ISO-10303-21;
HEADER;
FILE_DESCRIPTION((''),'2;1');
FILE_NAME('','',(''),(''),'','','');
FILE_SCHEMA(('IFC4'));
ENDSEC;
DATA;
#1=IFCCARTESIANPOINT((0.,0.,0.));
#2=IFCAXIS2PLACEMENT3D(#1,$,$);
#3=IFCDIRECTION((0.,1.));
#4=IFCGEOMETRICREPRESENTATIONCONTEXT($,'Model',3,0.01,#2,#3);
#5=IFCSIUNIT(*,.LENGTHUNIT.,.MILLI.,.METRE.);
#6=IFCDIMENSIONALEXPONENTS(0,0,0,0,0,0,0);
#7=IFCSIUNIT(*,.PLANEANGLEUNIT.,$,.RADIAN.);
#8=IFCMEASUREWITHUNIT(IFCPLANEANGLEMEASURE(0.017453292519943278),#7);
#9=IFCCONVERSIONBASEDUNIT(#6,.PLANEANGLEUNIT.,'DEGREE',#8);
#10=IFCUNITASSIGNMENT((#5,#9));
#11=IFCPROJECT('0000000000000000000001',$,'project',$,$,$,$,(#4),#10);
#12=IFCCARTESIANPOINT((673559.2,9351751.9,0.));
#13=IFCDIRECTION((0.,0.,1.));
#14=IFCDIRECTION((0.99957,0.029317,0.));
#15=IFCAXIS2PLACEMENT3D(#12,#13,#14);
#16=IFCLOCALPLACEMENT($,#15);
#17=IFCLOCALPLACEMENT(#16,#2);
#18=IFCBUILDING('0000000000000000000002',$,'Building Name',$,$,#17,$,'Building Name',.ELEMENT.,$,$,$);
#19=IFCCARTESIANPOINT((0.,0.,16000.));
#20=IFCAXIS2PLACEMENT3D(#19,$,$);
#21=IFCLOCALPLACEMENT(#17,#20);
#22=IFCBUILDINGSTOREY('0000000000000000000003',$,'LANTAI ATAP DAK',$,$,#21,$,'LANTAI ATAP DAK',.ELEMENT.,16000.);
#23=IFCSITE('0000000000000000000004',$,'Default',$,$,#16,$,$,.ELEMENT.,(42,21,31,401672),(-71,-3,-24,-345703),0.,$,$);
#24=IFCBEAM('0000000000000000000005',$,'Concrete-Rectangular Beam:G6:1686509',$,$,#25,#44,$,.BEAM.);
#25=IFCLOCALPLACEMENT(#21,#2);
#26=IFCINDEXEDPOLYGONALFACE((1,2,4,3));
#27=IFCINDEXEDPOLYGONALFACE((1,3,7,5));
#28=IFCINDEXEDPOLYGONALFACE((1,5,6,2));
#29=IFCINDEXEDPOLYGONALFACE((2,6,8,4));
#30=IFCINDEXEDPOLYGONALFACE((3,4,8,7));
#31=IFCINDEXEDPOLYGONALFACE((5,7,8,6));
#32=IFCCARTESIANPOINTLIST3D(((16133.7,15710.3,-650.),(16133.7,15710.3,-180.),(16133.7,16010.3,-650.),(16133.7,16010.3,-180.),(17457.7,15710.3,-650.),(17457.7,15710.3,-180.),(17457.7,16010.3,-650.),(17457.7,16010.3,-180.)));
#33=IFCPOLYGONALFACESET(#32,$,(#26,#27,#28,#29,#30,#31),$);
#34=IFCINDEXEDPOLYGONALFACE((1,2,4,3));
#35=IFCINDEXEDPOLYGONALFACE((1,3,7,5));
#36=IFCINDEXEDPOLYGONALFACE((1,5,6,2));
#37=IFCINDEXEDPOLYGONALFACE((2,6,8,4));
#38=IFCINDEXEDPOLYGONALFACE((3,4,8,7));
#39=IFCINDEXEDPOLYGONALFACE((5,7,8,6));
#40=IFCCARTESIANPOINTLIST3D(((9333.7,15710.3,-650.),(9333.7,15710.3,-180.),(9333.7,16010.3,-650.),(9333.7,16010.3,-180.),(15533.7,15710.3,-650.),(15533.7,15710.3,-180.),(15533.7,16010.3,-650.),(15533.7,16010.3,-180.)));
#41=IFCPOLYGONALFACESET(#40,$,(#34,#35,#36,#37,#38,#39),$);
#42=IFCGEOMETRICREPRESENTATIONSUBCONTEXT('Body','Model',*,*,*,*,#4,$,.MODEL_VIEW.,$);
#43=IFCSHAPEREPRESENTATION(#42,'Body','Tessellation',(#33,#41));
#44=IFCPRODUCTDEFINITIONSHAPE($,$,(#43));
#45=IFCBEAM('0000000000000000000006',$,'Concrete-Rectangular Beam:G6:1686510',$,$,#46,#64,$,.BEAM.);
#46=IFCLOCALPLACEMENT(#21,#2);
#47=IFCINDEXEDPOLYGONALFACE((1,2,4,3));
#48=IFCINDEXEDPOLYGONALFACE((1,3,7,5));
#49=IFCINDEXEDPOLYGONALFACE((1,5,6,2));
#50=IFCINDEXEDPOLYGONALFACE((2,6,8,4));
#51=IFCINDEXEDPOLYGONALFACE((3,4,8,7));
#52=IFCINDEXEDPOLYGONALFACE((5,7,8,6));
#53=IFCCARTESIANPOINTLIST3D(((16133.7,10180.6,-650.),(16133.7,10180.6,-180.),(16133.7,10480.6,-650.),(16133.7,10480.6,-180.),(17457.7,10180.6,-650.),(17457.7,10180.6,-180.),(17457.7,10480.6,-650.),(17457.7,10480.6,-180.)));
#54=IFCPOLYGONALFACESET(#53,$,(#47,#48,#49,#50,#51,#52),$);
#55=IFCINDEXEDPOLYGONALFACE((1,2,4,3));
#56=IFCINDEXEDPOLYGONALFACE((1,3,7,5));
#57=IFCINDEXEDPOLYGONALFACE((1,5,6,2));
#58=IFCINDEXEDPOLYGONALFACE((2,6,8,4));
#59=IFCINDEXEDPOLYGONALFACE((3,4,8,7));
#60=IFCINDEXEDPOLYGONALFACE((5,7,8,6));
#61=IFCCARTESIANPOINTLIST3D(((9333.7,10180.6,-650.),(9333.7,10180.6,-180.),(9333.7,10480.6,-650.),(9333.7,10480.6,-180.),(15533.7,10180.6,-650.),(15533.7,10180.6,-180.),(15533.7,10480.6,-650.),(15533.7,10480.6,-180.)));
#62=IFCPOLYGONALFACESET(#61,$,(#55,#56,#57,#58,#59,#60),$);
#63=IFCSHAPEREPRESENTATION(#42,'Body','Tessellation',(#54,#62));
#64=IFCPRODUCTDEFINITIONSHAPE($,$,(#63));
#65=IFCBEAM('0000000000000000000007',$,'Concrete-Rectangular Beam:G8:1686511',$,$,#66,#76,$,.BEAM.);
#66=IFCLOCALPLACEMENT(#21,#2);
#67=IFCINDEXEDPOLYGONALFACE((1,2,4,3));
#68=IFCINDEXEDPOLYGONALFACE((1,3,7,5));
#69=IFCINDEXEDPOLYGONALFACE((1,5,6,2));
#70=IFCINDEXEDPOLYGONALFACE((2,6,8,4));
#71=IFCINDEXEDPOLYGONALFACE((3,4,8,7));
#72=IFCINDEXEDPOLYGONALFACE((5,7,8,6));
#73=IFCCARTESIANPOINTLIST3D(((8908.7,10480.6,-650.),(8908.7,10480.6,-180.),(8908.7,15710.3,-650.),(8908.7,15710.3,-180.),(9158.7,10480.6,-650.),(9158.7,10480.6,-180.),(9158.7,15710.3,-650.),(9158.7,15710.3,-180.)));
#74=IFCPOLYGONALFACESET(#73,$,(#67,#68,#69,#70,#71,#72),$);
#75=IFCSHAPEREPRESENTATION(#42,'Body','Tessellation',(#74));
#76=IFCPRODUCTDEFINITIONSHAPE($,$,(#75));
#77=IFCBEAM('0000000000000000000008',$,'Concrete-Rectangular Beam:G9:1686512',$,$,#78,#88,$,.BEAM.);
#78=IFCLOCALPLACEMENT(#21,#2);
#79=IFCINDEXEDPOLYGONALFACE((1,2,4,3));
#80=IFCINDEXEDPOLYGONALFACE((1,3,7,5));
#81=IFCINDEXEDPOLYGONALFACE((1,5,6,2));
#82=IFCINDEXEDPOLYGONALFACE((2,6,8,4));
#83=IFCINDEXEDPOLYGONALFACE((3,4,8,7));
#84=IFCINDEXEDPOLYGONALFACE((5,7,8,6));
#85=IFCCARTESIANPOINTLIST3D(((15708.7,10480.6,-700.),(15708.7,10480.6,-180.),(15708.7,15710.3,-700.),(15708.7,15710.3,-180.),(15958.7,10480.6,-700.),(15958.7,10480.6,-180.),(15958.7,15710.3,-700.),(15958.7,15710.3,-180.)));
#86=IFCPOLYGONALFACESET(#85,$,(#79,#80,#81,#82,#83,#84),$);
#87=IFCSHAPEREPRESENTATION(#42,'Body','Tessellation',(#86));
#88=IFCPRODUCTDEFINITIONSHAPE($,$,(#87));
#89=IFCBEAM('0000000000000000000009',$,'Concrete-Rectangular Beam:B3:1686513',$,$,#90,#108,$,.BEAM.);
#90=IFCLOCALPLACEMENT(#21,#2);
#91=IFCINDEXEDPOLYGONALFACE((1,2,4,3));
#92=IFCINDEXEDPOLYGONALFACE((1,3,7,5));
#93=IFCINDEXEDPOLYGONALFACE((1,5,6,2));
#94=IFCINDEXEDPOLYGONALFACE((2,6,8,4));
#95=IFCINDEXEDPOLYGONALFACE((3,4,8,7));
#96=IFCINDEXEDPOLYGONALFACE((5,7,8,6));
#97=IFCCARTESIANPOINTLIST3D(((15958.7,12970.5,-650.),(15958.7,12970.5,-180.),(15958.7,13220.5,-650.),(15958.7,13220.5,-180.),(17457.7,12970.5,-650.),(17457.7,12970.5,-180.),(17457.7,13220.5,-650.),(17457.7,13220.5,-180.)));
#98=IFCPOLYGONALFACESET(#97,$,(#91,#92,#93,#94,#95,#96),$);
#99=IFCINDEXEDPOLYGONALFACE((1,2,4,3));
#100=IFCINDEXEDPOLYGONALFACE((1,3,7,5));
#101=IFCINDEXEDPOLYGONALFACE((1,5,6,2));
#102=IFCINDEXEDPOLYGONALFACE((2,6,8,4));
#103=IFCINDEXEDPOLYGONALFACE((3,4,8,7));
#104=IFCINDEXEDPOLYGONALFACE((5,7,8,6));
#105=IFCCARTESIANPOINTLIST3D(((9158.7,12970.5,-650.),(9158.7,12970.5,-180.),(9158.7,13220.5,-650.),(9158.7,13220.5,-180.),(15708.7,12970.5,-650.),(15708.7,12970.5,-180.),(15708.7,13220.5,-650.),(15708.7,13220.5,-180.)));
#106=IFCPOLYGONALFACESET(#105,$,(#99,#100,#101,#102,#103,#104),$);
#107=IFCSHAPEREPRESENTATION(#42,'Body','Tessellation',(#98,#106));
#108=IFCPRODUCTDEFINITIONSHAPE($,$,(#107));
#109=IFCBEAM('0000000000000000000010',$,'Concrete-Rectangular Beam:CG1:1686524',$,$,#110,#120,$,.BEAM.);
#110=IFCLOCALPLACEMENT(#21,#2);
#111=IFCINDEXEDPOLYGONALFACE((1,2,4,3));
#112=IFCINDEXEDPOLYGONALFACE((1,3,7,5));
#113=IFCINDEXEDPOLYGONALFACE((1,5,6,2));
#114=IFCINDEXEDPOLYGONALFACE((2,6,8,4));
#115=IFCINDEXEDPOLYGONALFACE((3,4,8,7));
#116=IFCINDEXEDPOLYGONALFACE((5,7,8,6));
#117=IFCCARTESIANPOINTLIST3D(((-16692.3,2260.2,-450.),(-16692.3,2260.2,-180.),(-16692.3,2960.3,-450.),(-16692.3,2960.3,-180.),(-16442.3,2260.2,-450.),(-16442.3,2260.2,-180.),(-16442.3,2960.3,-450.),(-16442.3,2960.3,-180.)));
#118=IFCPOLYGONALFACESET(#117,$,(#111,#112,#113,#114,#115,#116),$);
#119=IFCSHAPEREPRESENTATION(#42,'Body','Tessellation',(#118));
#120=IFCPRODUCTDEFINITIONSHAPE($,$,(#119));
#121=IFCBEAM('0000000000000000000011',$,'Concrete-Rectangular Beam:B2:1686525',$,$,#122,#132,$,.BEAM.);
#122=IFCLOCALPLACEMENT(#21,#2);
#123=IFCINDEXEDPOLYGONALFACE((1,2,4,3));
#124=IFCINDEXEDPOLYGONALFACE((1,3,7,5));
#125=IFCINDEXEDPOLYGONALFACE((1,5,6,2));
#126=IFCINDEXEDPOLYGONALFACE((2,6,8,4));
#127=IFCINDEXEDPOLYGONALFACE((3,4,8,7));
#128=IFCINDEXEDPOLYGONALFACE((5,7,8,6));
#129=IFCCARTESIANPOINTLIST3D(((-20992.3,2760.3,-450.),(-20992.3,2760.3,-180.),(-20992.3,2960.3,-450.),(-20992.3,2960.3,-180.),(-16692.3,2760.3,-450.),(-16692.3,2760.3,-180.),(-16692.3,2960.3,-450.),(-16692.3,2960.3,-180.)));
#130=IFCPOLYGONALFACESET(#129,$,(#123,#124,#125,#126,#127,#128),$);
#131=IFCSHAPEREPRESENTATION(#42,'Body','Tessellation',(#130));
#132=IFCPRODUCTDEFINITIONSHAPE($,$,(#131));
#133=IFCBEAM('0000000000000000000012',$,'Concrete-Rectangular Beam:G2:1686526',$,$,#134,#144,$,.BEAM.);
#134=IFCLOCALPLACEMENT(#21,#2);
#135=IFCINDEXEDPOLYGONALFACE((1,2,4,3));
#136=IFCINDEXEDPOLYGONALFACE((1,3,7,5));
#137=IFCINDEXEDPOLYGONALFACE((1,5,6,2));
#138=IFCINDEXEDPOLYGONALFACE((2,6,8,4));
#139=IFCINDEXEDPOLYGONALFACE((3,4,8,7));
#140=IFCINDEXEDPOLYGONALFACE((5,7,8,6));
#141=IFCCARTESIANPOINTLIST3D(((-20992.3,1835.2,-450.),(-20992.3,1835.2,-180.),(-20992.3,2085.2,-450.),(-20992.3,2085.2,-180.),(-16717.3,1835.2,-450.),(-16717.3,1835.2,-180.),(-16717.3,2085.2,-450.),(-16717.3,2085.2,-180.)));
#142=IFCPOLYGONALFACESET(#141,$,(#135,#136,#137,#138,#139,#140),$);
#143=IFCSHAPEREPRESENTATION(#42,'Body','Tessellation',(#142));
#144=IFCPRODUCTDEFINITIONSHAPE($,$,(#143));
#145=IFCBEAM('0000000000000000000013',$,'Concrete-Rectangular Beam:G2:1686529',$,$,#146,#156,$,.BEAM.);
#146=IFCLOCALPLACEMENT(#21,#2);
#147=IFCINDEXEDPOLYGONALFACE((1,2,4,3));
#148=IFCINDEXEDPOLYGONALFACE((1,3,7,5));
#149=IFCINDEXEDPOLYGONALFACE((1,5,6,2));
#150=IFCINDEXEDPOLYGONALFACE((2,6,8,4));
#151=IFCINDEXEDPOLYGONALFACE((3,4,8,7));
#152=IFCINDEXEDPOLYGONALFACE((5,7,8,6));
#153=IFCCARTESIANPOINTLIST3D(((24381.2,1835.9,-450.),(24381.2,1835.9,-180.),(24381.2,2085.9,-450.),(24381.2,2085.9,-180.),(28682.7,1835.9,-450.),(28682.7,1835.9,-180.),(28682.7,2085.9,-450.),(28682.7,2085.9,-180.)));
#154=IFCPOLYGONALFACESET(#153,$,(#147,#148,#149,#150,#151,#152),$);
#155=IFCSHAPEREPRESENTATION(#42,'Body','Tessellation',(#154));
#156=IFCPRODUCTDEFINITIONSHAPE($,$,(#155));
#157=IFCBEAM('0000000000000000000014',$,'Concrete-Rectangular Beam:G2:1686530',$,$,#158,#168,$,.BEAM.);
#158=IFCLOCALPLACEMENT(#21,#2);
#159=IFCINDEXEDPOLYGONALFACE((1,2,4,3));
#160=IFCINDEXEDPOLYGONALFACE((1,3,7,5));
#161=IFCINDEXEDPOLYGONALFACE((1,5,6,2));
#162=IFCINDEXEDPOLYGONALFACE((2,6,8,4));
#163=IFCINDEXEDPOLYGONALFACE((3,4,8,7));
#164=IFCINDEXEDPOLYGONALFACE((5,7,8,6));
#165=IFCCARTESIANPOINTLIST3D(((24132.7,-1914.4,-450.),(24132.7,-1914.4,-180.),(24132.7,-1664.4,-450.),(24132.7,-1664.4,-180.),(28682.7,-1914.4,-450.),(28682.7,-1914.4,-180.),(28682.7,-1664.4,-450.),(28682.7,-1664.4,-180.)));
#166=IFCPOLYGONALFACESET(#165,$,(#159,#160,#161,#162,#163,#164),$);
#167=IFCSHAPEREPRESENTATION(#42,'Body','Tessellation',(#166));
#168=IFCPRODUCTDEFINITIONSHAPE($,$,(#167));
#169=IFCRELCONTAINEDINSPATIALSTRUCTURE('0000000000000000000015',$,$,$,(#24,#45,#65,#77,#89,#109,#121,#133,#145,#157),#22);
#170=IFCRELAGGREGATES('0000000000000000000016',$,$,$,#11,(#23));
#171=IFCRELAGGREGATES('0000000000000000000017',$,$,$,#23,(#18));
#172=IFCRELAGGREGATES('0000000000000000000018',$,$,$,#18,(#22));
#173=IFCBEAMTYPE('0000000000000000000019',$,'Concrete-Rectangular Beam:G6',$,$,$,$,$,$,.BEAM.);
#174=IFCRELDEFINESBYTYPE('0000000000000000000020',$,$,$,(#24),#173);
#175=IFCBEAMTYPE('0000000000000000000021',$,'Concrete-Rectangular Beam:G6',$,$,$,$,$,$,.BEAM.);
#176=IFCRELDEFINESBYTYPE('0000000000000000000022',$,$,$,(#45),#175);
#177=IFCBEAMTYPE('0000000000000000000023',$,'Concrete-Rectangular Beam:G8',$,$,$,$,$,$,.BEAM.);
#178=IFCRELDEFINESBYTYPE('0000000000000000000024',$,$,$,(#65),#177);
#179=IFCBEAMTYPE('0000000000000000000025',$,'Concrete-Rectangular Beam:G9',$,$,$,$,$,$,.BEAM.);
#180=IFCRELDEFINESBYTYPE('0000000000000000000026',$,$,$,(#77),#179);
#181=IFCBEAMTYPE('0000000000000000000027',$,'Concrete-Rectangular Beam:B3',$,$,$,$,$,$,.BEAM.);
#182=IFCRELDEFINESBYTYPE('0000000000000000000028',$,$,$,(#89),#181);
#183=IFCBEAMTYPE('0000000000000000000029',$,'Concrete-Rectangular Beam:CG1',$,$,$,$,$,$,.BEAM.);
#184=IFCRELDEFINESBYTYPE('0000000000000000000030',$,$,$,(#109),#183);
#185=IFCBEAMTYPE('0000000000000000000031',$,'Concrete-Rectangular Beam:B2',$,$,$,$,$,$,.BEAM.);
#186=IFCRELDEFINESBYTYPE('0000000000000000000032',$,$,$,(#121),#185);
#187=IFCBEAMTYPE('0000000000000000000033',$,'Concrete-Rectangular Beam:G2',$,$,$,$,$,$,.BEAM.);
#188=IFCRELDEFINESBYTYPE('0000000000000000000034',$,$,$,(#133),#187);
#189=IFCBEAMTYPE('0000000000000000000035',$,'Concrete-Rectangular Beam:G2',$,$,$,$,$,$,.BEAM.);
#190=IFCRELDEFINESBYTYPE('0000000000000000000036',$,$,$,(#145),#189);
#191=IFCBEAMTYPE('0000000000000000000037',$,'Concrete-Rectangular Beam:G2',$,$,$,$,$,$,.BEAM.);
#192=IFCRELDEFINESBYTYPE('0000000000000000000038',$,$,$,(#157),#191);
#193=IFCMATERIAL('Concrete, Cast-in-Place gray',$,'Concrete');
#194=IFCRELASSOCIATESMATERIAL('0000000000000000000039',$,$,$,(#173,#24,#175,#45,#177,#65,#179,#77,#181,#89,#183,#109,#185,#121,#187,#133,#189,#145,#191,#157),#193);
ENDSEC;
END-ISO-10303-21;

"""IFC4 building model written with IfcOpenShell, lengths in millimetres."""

from ifc_helpers import new_model, entity, si_unit, converted_unit, direction, frame, origin, place, context, subcontext, project, spatial, indexed_curve, outline, extrude, source, transform, mapped, material, type_object, type_shapes, element, save


model = new_model("IFC4")

# Units and contexts
model_context = context("Model", 3, precision=0.01, world=origin(), true_north=direction((0.0, 1.0)))
body_context = subcontext(model_context, "Body", "Model", "MODEL_VIEW")
ifc_project = project(units=[si_unit("LENGTHUNIT", "METRE", prefix="MILLI"), converted_unit("PLANEANGLEUNIT", "DEGREE", entity("IfcPlaneAngleMeasure", 0.017453292519943278), si_unit("PLANEANGLEUNIT", "RADIAN"), dimensions=[0, 0, 0, 0, 0, 0, 0])], contexts=[model_context])

# Site, building, storey
site_placement = place(None, frame((673559.2, 9351751.9, 0.0), z_axis=(0.0, 0.0, 1.0), x_axis=(0.99957, 0.029317, 0.0)))
site = spatial("IfcSite", under=ifc_project, at=site_placement, Name="Default", CompositionType="ELEMENT", RefLatitude=(42, 21, 31, 401672), RefLongitude=(-71, -3, -24, -345703), RefElevation=0.0)
building_placement = place(site_placement, origin())
building = spatial("IfcBuilding", under=site, at=building_placement, Name="Building Name", LongName="Building Name", CompositionType="ELEMENT")
storey_placement = place(building_placement, frame((0.0, 0.0, 16000.0)))
storey = spatial("IfcBuildingStorey", under=building, at=storey_placement, Name="LANTAI ATAP DAK", LongName="LANTAI ATAP DAK", CompositionType="ELEMENT", Elevation=16000.0)

# Beams
ifc_material = material(Name="Concrete, Cast-in-Place gray", Category="Concrete")
beam_type_1 = type_object("IfcBeamType", Name="Concrete-Rectangular Beam:G6", PredefinedType="BEAM", material=ifc_material)
shared_shape_1 = source(origin(), body_context, "Body", "SweptSolid", [
    extrude(outline(indexed_curve([(-235.0, -150.0), (235.0, -150.0), (235.0, 150.0), (-235.0, 150.0), (-235.0, -150.0)], self_intersect=False)), frame((16133.7, 15860.3, 15585.0), z_axis=(1.0, 0.0, 0.0), x_axis=(0.0, 0.0, -1.0)), (0.0, 0.0, 1.0), 1324.0),
    extrude(outline(indexed_curve([(-235.0, -150.0), (235.0, -150.0), (235.0, 150.0), (-235.0, 150.0), (-235.0, -150.0)], self_intersect=False)), frame((9333.7, 15860.3, 15585.0), z_axis=(1.0, 0.0, 0.0), x_axis=(0.0, 0.0, -1.0)), (0.0, 0.0, 1.0), 6200.0),
])
type_shapes(beam_type_1, [shared_shape_1])
beam_1_placement = place(storey_placement, frame((0.0, 0.0, -16000.0)))
element("IfcBeam", 1, at=beam_1_placement, inside=storey, type_object=beam_type_1, material=ifc_material, Name="Concrete-Rectangular Beam:G6:1686509", PredefinedType="BEAM", context=body_context, shape_type="MappedRepresentation", body=[
    mapped(shared_shape_1, transform((0.0, 0.0, 0.0), scale=1.0)),
])
beam_type_2 = type_object("IfcBeamType", Name="Concrete-Rectangular Beam:G6", PredefinedType="BEAM", material=ifc_material)
shared_shape_2 = source(origin(), body_context, "Body", "SweptSolid", [
    extrude(outline(indexed_curve([(-235.0, -150.0), (235.0, -150.0), (235.0, 150.0), (-235.0, 150.0), (-235.0, -150.0)], self_intersect=False)), frame((16133.7, 10330.6, 15585.0), z_axis=(1.0, 0.0, 0.0), x_axis=(0.0, 0.0, -1.0)), (0.0, 0.0, 1.0), 1324.0),
    extrude(outline(indexed_curve([(-235.0, -150.0), (235.0, -150.0), (235.0, 150.0), (-235.0, 150.0), (-235.0, -150.0)], self_intersect=False)), frame((9333.7, 10330.6, 15585.0), z_axis=(1.0, 0.0, 0.0), x_axis=(0.0, 0.0, -1.0)), (0.0, 0.0, 1.0), 6200.0),
])
type_shapes(beam_type_2, [shared_shape_2])
beam_2_placement = place(storey_placement, frame((0.0, 0.0, -16000.0)))
element("IfcBeam", 2, at=beam_2_placement, inside=storey, type_object=beam_type_2, material=ifc_material, Name="Concrete-Rectangular Beam:G6:1686510", PredefinedType="BEAM", context=body_context, shape_type="MappedRepresentation", body=[
    mapped(shared_shape_2, transform((0.0, 0.0, 0.0), scale=1.0)),
])
beam_type_3 = type_object("IfcBeamType", Name="Concrete-Rectangular Beam:G8", PredefinedType="BEAM", material=ifc_material)
shared_shape_3 = source(origin(), body_context, "Body", "SweptSolid", [
    extrude(outline(indexed_curve([(-125.0, -235.0), (125.0, -235.0), (125.0, 235.0), (-125.0, 235.0), (-125.0, -235.0)], self_intersect=False)), frame((9033.7, 15710.3, 15585.0), z_axis=(0.0, -1.0, 0.0), x_axis=(-1.0, 0.0, 0.0)), (0.0, 0.0, 1.0), 5229.7),
])
type_shapes(beam_type_3, [shared_shape_3])
beam_3_placement = place(storey_placement, frame((0.0, 0.0, -16000.0)))
element("IfcBeam", 3, at=beam_3_placement, inside=storey, type_object=beam_type_3, material=ifc_material, Name="Concrete-Rectangular Beam:G8:1686511", PredefinedType="BEAM", context=body_context, shape_type="MappedRepresentation", body=[
    mapped(shared_shape_3, transform((0.0, 0.0, 0.0), scale=1.0)),
])
beam_type_4 = type_object("IfcBeamType", Name="Concrete-Rectangular Beam:G9", PredefinedType="BEAM", material=ifc_material)
shared_shape_4 = source(origin(), body_context, "Body", "SweptSolid", [
    extrude(outline(indexed_curve([(-125.0, -260.0), (125.0, -260.0), (125.0, 260.0), (-125.0, 260.0), (-125.0, -260.0)], self_intersect=False)), frame((15833.7, 15710.3, 15560.0), z_axis=(0.0, -1.0, 0.0), x_axis=(-1.0, 0.0, 0.0)), (0.0, 0.0, 1.0), 5229.7),
])
type_shapes(beam_type_4, [shared_shape_4])
beam_4_placement = place(storey_placement, frame((0.0, 0.0, -16000.0)))
element("IfcBeam", 4, at=beam_4_placement, inside=storey, type_object=beam_type_4, material=ifc_material, Name="Concrete-Rectangular Beam:G9:1686512", PredefinedType="BEAM", context=body_context, shape_type="MappedRepresentation", body=[
    mapped(shared_shape_4, transform((0.0, 0.0, 0.0), scale=1.0)),
])
beam_type_5 = type_object("IfcBeamType", Name="Concrete-Rectangular Beam:B3", PredefinedType="BEAM", material=ifc_material)
shared_shape_5 = source(origin(), body_context, "Body", "SweptSolid", [
    extrude(outline(indexed_curve([(-235.0, -125.0), (235.0, -125.0), (235.0, 125.0), (-235.0, 125.0), (-235.0, -125.0)], self_intersect=False)), frame((15958.7, 13095.5, 15585.0), z_axis=(1.0, 0.0, 0.0), x_axis=(0.0, 0.0, -1.0)), (0.0, 0.0, 1.0), 1499.0),
    extrude(outline(indexed_curve([(-235.0, -125.0), (235.0, -125.0), (235.0, 125.0), (-235.0, 125.0), (-235.0, -125.0)], self_intersect=False)), frame((9158.7, 13095.5, 15585.0), z_axis=(1.0, 0.0, 0.0), x_axis=(0.0, 0.0, -1.0)), (0.0, 0.0, 1.0), 6550.0),
])
type_shapes(beam_type_5, [shared_shape_5])
beam_5_placement = place(storey_placement, frame((0.0, 0.0, -16000.0)))
element("IfcBeam", 5, at=beam_5_placement, inside=storey, type_object=beam_type_5, material=ifc_material, Name="Concrete-Rectangular Beam:B3:1686513", PredefinedType="BEAM", context=body_context, shape_type="MappedRepresentation", body=[
    mapped(shared_shape_5, transform((0.0, 0.0, 0.0), scale=1.0)),
])
beam_type_6 = type_object("IfcBeamType", Name="Concrete-Rectangular Beam:CG1", PredefinedType="BEAM", material=ifc_material)
shared_shape_6 = source(origin(), body_context, "Body", "SweptSolid", [
    extrude(outline(indexed_curve([(-125.0, -135.0), (125.0, -135.0), (125.0, 135.0), (-125.0, 135.0), (-125.0, -135.0)], self_intersect=False)), frame((-16567.3, 2260.2, 15685.0), z_axis=(0.0, 1.0, 0.0), x_axis=(-1.0, 0.0, 0.0)), (0.0, 0.0, 1.0), 700.1),
])
type_shapes(beam_type_6, [shared_shape_6])
beam_6_placement = place(storey_placement, frame((0.0, 0.0, -16000.0)))
element("IfcBeam", 6, at=beam_6_placement, inside=storey, type_object=beam_type_6, material=ifc_material, Name="Concrete-Rectangular Beam:CG1:1686524", PredefinedType="BEAM", context=body_context, shape_type="MappedRepresentation", body=[
    mapped(shared_shape_6, transform((0.0, 0.0, 0.0), scale=1.0)),
])
beam_type_7 = type_object("IfcBeamType", Name="Concrete-Rectangular Beam:B2", PredefinedType="BEAM", material=ifc_material)
shared_shape_7 = source(origin(), body_context, "Body", "SweptSolid", [
    extrude(outline(indexed_curve([(-135.0, -100.0), (135.0, -100.0), (135.0, 100.0), (-135.0, 100.0), (-135.0, -100.0)], self_intersect=False)), frame((-20992.3, 2860.3, 15685.0), z_axis=(1.0, 0.0, 0.0), x_axis=(0.0, 0.0, -1.0)), (0.0, 0.0, 1.0), 4300.0),
])
type_shapes(beam_type_7, [shared_shape_7])
beam_7_placement = place(storey_placement, frame((0.0, 0.0, -16000.0)))
element("IfcBeam", 7, at=beam_7_placement, inside=storey, type_object=beam_type_7, material=ifc_material, Name="Concrete-Rectangular Beam:B2:1686525", PredefinedType="BEAM", context=body_context, shape_type="MappedRepresentation", body=[
    mapped(shared_shape_7, transform((0.0, 0.0, 0.0), scale=1.0)),
])
beam_type_8 = type_object("IfcBeamType", Name="Concrete-Rectangular Beam:G2", PredefinedType="BEAM", material=ifc_material)
shared_shape_8 = source(origin(), body_context, "Body", "SweptSolid", [
    extrude(outline(indexed_curve([(-135.0, -125.0), (135.0, -125.0), (135.0, 125.0), (-135.0, 125.0), (-135.0, -125.0)], self_intersect=False)), frame((-20992.3, 1960.2, 15685.0), z_axis=(1.0, 0.0, 0.0), x_axis=(0.0, 0.0, -1.0)), (0.0, 0.0, 1.0), 4275.0),
])
type_shapes(beam_type_8, [shared_shape_8])
beam_8_placement = place(storey_placement, frame((0.0, 0.0, -16000.0)))
element("IfcBeam", 8, at=beam_8_placement, inside=storey, type_object=beam_type_8, material=ifc_material, Name="Concrete-Rectangular Beam:G2:1686526", PredefinedType="BEAM", context=body_context, shape_type="MappedRepresentation", body=[
    mapped(shared_shape_8, transform((0.0, 0.0, 0.0), scale=1.0)),
])
beam_type_9 = type_object("IfcBeamType", Name="Concrete-Rectangular Beam:G2", PredefinedType="BEAM", material=ifc_material)
shared_shape_9 = source(origin(), body_context, "Body", "SweptSolid", [
    extrude(outline(indexed_curve([(-135.0, -125.0), (135.0, -125.0), (135.0, 125.0), (-135.0, 125.0), (-135.0, -125.0)], self_intersect=False)), frame((28682.7, 1960.9, 15685.0), z_axis=(-1.0, 0.0, 0.0), x_axis=(0.0, 0.0, -1.0)), (0.0, 0.0, 1.0), 4301.5),
])
type_shapes(beam_type_9, [shared_shape_9])
beam_9_placement = place(storey_placement, frame((0.0, 0.0, -16000.0)))
element("IfcBeam", 9, at=beam_9_placement, inside=storey, type_object=beam_type_9, material=ifc_material, Name="Concrete-Rectangular Beam:G2:1686529", PredefinedType="BEAM", context=body_context, shape_type="MappedRepresentation", body=[
    mapped(shared_shape_9, transform((0.0, 0.0, 0.0), scale=1.0)),
])
beam_type_10 = type_object("IfcBeamType", Name="Concrete-Rectangular Beam:G2", PredefinedType="BEAM", material=ifc_material)
shared_shape_10 = source(origin(), body_context, "Body", "SweptSolid", [
    extrude(outline(indexed_curve([(-135.0, -125.0), (135.0, -125.0), (135.0, 125.0), (-135.0, 125.0), (-135.0, -125.0)], self_intersect=False)), frame((28682.7, -1789.4, 15685.0), z_axis=(-1.0, 0.0, 0.0), x_axis=(0.0, 0.0, -1.0)), (0.0, 0.0, 1.0), 4550.0),
])
type_shapes(beam_type_10, [shared_shape_10])
beam_10_placement = place(storey_placement, frame((0.0, 0.0, -16000.0)))
element("IfcBeam", 10, at=beam_10_placement, inside=storey, type_object=beam_type_10, material=ifc_material, Name="Concrete-Rectangular Beam:G2:1686530", PredefinedType="BEAM", context=body_context, shape_type="MappedRepresentation", body=[
    mapped(shared_shape_10, transform((0.0, 0.0, 0.0), scale=1.0)),
])

save(model, "model.ifc")
